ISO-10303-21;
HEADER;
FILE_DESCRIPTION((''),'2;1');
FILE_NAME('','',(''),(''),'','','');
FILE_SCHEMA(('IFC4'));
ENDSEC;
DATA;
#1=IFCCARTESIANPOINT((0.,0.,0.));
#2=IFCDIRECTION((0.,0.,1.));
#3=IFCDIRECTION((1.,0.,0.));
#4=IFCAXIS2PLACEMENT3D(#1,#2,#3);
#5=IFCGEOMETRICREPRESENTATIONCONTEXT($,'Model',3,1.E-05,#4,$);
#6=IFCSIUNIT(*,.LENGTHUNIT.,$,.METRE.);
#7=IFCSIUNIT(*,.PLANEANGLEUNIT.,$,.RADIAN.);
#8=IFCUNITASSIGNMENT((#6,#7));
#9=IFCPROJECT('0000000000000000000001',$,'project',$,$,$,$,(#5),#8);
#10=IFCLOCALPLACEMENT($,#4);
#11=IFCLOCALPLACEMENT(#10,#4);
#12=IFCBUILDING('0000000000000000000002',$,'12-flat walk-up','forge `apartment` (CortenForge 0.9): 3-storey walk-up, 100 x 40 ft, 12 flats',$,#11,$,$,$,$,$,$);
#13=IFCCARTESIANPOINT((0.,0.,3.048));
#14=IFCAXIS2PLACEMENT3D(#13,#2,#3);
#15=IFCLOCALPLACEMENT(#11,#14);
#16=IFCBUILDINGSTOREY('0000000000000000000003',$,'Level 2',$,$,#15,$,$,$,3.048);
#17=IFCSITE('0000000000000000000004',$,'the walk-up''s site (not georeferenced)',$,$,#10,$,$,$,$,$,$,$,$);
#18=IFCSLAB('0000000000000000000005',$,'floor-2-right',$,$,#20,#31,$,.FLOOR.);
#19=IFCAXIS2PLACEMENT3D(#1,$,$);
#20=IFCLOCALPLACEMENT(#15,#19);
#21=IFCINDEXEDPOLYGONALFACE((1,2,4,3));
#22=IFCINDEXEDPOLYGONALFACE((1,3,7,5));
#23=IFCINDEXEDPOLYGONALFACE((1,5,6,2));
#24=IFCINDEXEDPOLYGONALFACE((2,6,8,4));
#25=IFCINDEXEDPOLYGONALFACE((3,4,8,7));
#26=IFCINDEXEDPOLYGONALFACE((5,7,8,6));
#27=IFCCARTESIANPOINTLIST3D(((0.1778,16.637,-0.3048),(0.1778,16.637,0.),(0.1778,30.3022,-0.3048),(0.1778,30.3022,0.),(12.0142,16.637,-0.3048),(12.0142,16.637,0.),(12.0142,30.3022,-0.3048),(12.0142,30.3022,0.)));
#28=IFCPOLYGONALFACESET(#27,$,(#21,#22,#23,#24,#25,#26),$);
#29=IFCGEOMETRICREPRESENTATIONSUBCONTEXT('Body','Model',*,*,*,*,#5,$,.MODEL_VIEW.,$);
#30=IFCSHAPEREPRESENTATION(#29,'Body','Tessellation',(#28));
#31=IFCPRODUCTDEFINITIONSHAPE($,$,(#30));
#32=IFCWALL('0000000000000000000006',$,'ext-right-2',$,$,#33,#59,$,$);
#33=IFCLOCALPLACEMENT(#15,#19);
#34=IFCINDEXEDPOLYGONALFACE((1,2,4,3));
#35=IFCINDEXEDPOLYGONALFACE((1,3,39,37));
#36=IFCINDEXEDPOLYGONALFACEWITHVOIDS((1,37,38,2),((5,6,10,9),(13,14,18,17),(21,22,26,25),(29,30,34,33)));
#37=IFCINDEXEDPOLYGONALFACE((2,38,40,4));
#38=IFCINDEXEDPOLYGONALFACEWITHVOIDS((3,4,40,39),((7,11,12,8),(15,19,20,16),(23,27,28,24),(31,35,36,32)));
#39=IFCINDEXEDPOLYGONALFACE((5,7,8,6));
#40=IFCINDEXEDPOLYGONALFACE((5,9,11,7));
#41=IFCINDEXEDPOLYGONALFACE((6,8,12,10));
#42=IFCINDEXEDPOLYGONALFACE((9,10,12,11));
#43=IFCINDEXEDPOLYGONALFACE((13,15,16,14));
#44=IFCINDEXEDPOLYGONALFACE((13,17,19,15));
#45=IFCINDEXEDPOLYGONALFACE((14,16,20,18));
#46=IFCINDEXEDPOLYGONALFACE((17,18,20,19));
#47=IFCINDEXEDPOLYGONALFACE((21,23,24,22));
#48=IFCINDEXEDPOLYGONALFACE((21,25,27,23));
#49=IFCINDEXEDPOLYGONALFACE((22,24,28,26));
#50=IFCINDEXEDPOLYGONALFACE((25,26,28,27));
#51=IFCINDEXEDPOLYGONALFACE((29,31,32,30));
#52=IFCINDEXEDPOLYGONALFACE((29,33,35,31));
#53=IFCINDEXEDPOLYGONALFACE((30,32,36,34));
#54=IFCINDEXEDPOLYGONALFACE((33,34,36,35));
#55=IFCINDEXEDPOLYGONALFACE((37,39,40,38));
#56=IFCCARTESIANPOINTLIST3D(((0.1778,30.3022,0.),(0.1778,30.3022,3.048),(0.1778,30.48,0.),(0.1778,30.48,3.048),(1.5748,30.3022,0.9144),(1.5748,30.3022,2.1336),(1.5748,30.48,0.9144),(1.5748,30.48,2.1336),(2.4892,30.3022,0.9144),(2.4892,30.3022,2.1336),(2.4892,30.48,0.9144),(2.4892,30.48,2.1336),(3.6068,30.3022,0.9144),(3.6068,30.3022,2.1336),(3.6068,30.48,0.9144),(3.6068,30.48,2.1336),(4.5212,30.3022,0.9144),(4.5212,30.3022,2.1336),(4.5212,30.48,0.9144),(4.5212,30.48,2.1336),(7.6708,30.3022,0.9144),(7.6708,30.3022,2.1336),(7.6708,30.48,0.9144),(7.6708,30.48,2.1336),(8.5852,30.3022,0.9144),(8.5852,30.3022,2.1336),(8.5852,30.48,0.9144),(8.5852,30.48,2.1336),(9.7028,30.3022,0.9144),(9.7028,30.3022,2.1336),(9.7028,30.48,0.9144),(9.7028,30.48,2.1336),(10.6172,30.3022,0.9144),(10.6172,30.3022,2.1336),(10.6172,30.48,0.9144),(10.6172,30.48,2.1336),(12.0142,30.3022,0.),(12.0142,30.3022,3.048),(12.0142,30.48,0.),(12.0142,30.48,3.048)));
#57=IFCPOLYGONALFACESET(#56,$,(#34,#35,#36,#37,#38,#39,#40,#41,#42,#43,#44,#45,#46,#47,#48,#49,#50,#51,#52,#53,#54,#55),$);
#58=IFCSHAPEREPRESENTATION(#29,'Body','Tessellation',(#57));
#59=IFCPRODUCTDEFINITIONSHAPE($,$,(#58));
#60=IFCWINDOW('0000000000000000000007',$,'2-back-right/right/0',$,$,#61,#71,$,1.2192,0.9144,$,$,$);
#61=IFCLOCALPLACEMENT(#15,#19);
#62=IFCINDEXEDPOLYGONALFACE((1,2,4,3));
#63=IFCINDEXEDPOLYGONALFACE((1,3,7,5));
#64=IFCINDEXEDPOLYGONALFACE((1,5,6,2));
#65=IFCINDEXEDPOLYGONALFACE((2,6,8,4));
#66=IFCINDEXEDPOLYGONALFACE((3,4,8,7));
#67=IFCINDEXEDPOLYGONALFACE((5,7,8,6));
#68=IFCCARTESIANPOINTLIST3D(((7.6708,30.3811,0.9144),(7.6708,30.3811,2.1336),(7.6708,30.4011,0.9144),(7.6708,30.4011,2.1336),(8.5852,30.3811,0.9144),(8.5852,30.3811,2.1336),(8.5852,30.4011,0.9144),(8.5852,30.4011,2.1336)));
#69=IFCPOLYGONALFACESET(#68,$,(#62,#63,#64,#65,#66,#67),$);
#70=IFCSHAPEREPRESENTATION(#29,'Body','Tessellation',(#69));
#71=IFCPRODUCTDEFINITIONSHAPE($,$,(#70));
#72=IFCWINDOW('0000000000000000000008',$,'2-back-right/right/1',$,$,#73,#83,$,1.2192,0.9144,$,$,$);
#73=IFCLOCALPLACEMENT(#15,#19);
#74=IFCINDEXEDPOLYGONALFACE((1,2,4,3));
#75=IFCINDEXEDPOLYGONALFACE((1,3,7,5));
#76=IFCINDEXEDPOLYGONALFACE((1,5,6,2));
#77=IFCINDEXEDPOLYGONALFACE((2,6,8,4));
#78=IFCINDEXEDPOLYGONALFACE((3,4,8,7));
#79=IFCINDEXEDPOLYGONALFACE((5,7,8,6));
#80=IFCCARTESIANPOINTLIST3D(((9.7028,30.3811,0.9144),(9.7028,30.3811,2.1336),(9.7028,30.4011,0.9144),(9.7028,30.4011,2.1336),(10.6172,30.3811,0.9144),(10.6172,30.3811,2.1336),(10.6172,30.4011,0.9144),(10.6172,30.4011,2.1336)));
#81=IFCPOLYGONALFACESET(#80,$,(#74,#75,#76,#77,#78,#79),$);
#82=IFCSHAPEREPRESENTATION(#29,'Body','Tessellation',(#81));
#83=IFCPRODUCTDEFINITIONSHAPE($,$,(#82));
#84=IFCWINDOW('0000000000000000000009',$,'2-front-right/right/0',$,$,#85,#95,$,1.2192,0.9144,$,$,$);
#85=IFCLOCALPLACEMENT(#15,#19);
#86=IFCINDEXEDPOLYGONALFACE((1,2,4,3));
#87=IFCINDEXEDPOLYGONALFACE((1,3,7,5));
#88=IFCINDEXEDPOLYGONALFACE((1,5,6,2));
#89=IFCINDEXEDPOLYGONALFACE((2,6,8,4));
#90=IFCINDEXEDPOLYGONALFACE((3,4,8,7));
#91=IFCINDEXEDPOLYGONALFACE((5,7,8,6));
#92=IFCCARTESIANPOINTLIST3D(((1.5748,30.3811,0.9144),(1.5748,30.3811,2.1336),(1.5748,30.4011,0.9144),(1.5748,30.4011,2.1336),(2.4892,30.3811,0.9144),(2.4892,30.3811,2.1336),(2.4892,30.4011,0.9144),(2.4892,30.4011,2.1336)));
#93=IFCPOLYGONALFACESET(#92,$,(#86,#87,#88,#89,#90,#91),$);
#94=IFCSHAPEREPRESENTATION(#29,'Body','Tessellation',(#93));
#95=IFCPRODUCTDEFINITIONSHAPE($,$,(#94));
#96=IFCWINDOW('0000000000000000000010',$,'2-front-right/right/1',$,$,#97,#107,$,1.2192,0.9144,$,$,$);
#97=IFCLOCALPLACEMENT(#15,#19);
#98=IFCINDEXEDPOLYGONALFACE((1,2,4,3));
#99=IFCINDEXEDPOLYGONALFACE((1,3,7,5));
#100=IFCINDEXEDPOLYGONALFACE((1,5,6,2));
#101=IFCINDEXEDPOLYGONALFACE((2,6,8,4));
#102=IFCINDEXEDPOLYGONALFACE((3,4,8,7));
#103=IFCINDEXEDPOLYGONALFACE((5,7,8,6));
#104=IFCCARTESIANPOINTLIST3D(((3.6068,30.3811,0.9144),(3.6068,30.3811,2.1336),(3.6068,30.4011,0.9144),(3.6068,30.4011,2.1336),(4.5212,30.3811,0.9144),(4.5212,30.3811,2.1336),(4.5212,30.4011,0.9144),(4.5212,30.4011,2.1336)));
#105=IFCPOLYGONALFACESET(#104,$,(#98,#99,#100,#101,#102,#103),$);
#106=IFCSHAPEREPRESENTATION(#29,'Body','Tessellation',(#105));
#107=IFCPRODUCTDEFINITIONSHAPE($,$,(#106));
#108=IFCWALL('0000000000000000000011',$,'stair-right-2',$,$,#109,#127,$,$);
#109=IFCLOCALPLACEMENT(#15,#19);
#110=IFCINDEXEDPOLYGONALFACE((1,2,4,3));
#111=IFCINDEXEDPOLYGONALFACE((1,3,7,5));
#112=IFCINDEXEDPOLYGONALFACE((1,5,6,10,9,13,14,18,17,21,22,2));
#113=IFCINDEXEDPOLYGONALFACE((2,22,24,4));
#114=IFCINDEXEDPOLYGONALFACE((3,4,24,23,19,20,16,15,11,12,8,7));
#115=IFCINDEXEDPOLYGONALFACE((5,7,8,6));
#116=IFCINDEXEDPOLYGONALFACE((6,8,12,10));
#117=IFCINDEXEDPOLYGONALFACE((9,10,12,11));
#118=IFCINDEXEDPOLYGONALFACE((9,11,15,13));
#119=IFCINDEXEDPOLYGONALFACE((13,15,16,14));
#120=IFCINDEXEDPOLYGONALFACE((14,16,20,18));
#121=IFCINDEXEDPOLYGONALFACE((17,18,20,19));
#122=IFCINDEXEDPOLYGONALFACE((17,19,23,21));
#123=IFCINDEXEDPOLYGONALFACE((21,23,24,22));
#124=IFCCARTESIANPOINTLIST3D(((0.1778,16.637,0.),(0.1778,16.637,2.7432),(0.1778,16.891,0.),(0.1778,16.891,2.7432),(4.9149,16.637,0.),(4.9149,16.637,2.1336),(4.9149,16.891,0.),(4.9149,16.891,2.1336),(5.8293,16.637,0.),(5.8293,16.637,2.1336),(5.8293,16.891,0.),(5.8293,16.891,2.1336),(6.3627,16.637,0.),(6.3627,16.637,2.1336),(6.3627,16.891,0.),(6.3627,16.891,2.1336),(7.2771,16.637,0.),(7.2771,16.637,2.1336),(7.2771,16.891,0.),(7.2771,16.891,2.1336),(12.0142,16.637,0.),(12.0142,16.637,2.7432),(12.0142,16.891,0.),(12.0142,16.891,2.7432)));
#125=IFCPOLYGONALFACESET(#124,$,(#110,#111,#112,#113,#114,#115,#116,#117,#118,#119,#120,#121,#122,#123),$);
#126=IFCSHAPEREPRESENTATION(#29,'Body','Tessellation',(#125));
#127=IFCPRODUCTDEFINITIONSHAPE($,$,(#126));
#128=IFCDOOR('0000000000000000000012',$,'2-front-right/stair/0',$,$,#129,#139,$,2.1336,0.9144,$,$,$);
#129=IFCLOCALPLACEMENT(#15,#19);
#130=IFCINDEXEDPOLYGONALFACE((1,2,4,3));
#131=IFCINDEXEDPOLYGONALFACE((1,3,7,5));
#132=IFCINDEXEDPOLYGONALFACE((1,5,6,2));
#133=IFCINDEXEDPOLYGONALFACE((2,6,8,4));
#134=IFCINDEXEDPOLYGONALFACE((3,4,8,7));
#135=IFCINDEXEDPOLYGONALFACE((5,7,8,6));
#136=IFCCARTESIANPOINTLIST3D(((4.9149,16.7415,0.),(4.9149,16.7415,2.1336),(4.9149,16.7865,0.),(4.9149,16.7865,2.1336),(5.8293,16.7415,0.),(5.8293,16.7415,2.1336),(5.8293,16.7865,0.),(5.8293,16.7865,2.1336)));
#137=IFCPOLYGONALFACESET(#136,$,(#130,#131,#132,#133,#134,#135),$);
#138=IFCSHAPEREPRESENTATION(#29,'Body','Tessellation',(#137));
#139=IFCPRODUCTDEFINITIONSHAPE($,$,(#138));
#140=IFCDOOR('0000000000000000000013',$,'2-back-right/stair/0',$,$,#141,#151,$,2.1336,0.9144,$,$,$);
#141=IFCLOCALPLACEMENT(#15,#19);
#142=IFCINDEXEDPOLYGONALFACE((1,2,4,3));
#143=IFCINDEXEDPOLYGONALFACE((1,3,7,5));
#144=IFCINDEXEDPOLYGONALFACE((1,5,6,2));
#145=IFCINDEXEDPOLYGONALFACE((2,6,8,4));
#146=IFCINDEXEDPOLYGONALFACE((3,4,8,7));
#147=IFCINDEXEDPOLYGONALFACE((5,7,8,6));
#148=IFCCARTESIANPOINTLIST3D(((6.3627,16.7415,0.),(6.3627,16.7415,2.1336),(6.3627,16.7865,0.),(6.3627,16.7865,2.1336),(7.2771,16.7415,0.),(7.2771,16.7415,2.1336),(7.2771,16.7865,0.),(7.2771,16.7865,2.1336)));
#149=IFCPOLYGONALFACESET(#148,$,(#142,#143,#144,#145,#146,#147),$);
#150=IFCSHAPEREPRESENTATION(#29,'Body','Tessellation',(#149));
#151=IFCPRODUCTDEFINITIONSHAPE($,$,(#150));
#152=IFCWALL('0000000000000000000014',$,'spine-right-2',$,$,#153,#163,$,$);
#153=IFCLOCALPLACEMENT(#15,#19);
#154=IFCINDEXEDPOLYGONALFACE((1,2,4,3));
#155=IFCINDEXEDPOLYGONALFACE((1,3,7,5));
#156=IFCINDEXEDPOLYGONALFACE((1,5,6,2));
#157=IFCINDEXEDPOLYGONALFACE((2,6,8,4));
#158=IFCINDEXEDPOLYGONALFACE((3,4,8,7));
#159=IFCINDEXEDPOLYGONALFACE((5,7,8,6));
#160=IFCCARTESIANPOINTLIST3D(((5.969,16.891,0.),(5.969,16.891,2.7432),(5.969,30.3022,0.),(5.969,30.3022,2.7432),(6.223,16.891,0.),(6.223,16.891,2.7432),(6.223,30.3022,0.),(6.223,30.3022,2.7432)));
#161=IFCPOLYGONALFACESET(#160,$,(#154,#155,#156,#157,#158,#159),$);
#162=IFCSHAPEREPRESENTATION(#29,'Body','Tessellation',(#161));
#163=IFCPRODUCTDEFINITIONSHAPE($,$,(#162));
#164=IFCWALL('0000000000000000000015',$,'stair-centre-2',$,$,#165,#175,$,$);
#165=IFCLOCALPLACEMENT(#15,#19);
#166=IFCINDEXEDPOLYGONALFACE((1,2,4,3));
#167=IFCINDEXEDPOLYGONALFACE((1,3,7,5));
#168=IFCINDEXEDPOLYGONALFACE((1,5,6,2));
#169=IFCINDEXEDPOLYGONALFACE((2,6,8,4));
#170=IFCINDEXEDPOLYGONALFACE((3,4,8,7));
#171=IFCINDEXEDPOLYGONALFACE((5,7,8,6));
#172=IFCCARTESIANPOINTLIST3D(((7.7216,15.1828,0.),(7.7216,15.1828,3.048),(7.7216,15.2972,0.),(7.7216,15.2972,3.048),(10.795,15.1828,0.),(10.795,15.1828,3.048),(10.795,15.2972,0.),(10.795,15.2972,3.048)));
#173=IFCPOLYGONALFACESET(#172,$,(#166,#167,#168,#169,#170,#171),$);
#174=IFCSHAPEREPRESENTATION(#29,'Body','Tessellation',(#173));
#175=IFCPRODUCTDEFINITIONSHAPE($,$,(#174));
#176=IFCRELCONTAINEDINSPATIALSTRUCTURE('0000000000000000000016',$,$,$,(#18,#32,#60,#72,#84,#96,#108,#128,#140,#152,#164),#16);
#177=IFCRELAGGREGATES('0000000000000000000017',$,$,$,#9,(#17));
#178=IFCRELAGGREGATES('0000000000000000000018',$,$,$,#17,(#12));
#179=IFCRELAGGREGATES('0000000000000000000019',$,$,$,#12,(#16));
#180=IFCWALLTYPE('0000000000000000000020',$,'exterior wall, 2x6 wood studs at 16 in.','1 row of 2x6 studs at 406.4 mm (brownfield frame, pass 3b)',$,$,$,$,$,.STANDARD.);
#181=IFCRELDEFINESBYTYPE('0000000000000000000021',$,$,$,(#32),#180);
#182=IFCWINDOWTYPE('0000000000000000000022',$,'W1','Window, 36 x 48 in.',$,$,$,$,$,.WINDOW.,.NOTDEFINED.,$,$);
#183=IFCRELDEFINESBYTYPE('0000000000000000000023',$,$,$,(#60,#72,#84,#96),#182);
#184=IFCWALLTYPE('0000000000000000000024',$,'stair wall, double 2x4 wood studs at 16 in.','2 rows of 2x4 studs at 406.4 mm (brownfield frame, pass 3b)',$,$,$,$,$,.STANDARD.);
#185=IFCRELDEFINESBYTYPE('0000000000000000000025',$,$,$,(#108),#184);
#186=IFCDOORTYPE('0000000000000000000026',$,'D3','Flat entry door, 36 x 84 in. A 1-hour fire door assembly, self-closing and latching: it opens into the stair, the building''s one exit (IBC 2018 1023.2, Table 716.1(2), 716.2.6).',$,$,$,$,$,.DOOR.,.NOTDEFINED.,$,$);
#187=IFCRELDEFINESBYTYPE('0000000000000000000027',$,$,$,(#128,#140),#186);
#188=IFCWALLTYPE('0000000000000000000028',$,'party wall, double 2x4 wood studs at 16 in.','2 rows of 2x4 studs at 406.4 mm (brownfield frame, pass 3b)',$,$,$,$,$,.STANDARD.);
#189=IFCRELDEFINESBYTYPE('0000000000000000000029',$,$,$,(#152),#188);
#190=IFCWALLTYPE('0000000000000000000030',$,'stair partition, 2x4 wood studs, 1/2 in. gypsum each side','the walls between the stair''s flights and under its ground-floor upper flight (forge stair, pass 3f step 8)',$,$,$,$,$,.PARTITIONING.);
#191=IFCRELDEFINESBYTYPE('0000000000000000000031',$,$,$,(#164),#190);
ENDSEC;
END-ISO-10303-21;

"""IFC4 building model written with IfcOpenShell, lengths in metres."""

from ifc_helpers import new_model, si_unit, frame, frame_2d, origin, origin_with_axes, place, context, subcontext, project, spatial, rectangle, extrude, type_object, element, fill, save


model = new_model("IFC4")

# Units and contexts
model_context = context("Model", 3, precision=1e-05, world=origin_with_axes())
body_context = subcontext(model_context, "Body", "Model", "MODEL_VIEW")
ifc_project = project(units=[si_unit("LENGTHUNIT", "METRE"), si_unit("PLANEANGLEUNIT", "RADIAN")], contexts=[model_context])

# Site, building, storey
site_placement = place(None, origin_with_axes())
site = spatial("IfcSite", under=ifc_project, at=site_placement, Name="the walk-up's site (not georeferenced)")
building_placement = place(site_placement, origin_with_axes())
building = spatial("IfcBuilding", under=site, at=building_placement, Name="12-flat walk-up", Description="forge `apartment` (CortenForge 0.9): 3-storey walk-up, 100 x 40 ft, 12 flats")
storey_placement = place(building_placement, frame((0.0, 0.0, 3.048), z_axis=(0.0, 0.0, 1.0), x_axis=(1.0, 0.0, 0.0)))
storey = spatial("IfcBuildingStorey", under=building, at=storey_placement, Name="Level 2", Elevation=3.048)

# Slab
slab_placement = place(storey_placement, frame((0.1778, 16.637, -0.3048), z_axis=(0.0, 0.0, 1.0), x_axis=(1.0, 0.0, 0.0)))
element("IfcSlab", 1, at=slab_placement, inside=storey, Name="floor-2-right", PredefinedType="FLOOR", context=body_context, shape_type="SweptSolid", body=[
    extrude(rectangle(XDim=11.8364, YDim=13.6652, at=frame_2d((5.9182, 6.8326))), origin(), (0.0, 0.0, 1.0), 0.3048),
])

# Wall, openings, windows
wall_type_1 = type_object("IfcWallType", Name="exterior wall, 2x6 wood studs at 16 in.", Description="1 row of 2x6 studs at 406.4 mm (brownfield frame, pass 3b)", PredefinedType="STANDARD")
wall_1_placement = place(storey_placement, frame((0.1778, 30.3022, 0.0), z_axis=(0.0, 0.0, 1.0), x_axis=(1.0, 0.0, 0.0)))
wall_1 = element("IfcWall", 2, at=wall_1_placement, inside=storey, type_object=wall_type_1, Name="ext-right-2", context=body_context, shape_type="SweptSolid", body=[
    extrude(rectangle(XDim=11.8364, YDim=0.1778, at=frame_2d((5.9182, 0.0889))), origin(), (0.0, 0.0, 1.0), 3.048),
])
opening_1_placement = place(wall_1_placement, frame((8.4074, 0.1778, 0.9144), z_axis=(0.0, 0.0, 1.0), x_axis=(-1.0, 0.0, 0.0)))
opening_1 = element("IfcOpeningElement", 3, at=opening_1_placement, cuts=wall_1, PredefinedType="OPENING", context=body_context, shape_type="SweptSolid", body=[
    extrude(rectangle(XDim=0.9144, YDim=0.1778, at=frame_2d((0.4572, 0.0889))), origin(), (0.0, 0.0, 1.0), 1.2192),
])
opening_2_placement = place(wall_1_placement, frame((10.4394, 0.1778, 0.9144), z_axis=(0.0, 0.0, 1.0), x_axis=(-1.0, 0.0, 0.0)))
opening_2 = element("IfcOpeningElement", 4, at=opening_2_placement, cuts=wall_1, PredefinedType="OPENING", context=body_context, shape_type="SweptSolid", body=[
    extrude(rectangle(XDim=0.9144, YDim=0.1778, at=frame_2d((0.4572, 0.0889))), origin(), (0.0, 0.0, 1.0), 1.2192),
])
opening_3_placement = place(wall_1_placement, frame((2.3114, 0.1778, 0.9144), z_axis=(0.0, 0.0, 1.0), x_axis=(-1.0, 0.0, 0.0)))
opening_3 = element("IfcOpeningElement", 5, at=opening_3_placement, cuts=wall_1, PredefinedType="OPENING", context=body_context, shape_type="SweptSolid", body=[
    extrude(rectangle(XDim=0.9144, YDim=0.1778, at=frame_2d((0.4572, 0.0889))), origin(), (0.0, 0.0, 1.0), 1.2192),
])
opening_4_placement = place(wall_1_placement, frame((4.3434, 0.1778, 0.9144), z_axis=(0.0, 0.0, 1.0), x_axis=(-1.0, 0.0, 0.0)))
opening_4 = element("IfcOpeningElement", 6, at=opening_4_placement, cuts=wall_1, PredefinedType="OPENING", context=body_context, shape_type="SweptSolid", body=[
    extrude(rectangle(XDim=0.9144, YDim=0.1778, at=frame_2d((0.4572, 0.0889))), origin(), (0.0, 0.0, 1.0), 1.2192),
])
window_type = type_object("IfcWindowType", Name="W1", Description="Window, 36 x 48 in.", PartitioningType="NOTDEFINED", PredefinedType="WINDOW")
window_1_placement = place(opening_1_placement, frame((0.0, 0.0789, 0.0), z_axis=(0.0, 0.0, 1.0), x_axis=(1.0, 0.0, 0.0)))
window_1 = element("IfcWindow", 7, at=window_1_placement, inside=storey, type_object=window_type, Name="2-back-right/right/0", OverallHeight=1.2192, OverallWidth=0.9144, context=body_context, shape_type="SweptSolid", body=[
    extrude(rectangle(XDim=0.9144, YDim=0.02, at=frame_2d((0.4572, 0.01))), origin(), (0.0, 0.0, 1.0), 1.2192),
])
fill(opening_1, window_1)
window_2_placement = place(opening_2_placement, frame((0.0, 0.0789, 0.0), z_axis=(0.0, 0.0, 1.0), x_axis=(1.0, 0.0, 0.0)))
window_2 = element("IfcWindow", 8, at=window_2_placement, inside=storey, type_object=window_type, Name="2-back-right/right/1", OverallHeight=1.2192, OverallWidth=0.9144, context=body_context, shape_type="SweptSolid", body=[
    extrude(rectangle(XDim=0.9144, YDim=0.02, at=frame_2d((0.4572, 0.01))), origin(), (0.0, 0.0, 1.0), 1.2192),
])
fill(opening_2, window_2)
window_3_placement = place(opening_3_placement, frame((0.0, 0.0789, 0.0), z_axis=(0.0, 0.0, 1.0), x_axis=(1.0, 0.0, 0.0)))
window_3 = element("IfcWindow", 9, at=window_3_placement, inside=storey, type_object=window_type, Name="2-front-right/right/0", OverallHeight=1.2192, OverallWidth=0.9144, context=body_context, shape_type="SweptSolid", body=[
    extrude(rectangle(XDim=0.9144, YDim=0.02, at=frame_2d((0.4572, 0.01))), origin(), (0.0, 0.0, 1.0), 1.2192),
])
fill(opening_3, window_3)
window_4_placement = place(opening_4_placement, frame((0.0, 0.0789, 0.0), z_axis=(0.0, 0.0, 1.0), x_axis=(1.0, 0.0, 0.0)))
window_4 = element("IfcWindow", 10, at=window_4_placement, inside=storey, type_object=window_type, Name="2-front-right/right/1", OverallHeight=1.2192, OverallWidth=0.9144, context=body_context, shape_type="SweptSolid", body=[
    extrude(rectangle(XDim=0.9144, YDim=0.02, at=frame_2d((0.4572, 0.01))), origin(), (0.0, 0.0, 1.0), 1.2192),
])
fill(opening_4, window_4)

# Wall, openings, doors
wall_type_2 = type_object("IfcWallType", Name="stair wall, double 2x4 wood studs at 16 in.", Description="2 rows of 2x4 studs at 406.4 mm (brownfield frame, pass 3b)", PredefinedType="STANDARD")
wall_2_placement = place(storey_placement, frame((0.1778, 16.637, 0.0), z_axis=(0.0, 0.0, 1.0), x_axis=(1.0, 0.0, 0.0)))
wall_2 = element("IfcWall", 11, at=wall_2_placement, inside=storey, type_object=wall_type_2, Name="stair-right-2", context=body_context, shape_type="SweptSolid", body=[
    extrude(rectangle(XDim=11.8364, YDim=0.254, at=frame_2d((5.9182, 0.127))), origin(), (0.0, 0.0, 1.0), 2.7432),
])
opening_5_placement = place(wall_2_placement, frame((5.6515, 0.254, 0.0), z_axis=(0.0, 0.0, 1.0), x_axis=(-1.0, 0.0, 0.0)))
opening_5 = element("IfcOpeningElement", 12, at=opening_5_placement, cuts=wall_2, PredefinedType="OPENING", context=body_context, shape_type="SweptSolid", body=[
    extrude(rectangle(XDim=0.9144, YDim=0.254, at=frame_2d((0.4572, 0.127))), origin(), (0.0, 0.0, 1.0), 2.1336),
])
opening_6_placement = place(wall_2_placement, frame((7.0993, 0.254, 0.0), z_axis=(0.0, 0.0, 1.0), x_axis=(-1.0, 0.0, 0.0)))
opening_6 = element("IfcOpeningElement", 13, at=opening_6_placement, cuts=wall_2, PredefinedType="OPENING", context=body_context, shape_type="SweptSolid", body=[
    extrude(rectangle(XDim=0.9144, YDim=0.254, at=frame_2d((0.4572, 0.127))), origin(), (0.0, 0.0, 1.0), 2.1336),
])
door_type = type_object("IfcDoorType", Name="D3", Description="Flat entry door, 36 x 84 in. A 1-hour fire door assembly, self-closing and latching: it opens into the stair, the building's one exit (IBC 2018 1023.2, Table 716.1(2), 716.2.6).", OperationType="NOTDEFINED", PredefinedType="DOOR")
door_1_placement = place(opening_5_placement, frame((0.0, 0.1045, 0.0), z_axis=(0.0, 0.0, 1.0), x_axis=(1.0, 0.0, 0.0)))
door_1 = element("IfcDoor", 14, at=door_1_placement, inside=storey, type_object=door_type, Name="2-front-right/stair/0", OverallHeight=2.1336, OverallWidth=0.9144, context=body_context, shape_type="SweptSolid", body=[
    extrude(rectangle(XDim=0.9144, YDim=0.045, at=frame_2d((0.4572, 0.0225))), origin(), (0.0, 0.0, 1.0), 2.1336),
])
fill(opening_5, door_1)
door_2_placement = place(opening_6_placement, frame((0.0, 0.1045, 0.0), z_axis=(0.0, 0.0, 1.0), x_axis=(1.0, 0.0, 0.0)))
door_2 = element("IfcDoor", 15, at=door_2_placement, inside=storey, type_object=door_type, Name="2-back-right/stair/0", OverallHeight=2.1336, OverallWidth=0.9144, context=body_context, shape_type="SweptSolid", body=[
    extrude(rectangle(XDim=0.9144, YDim=0.045, at=frame_2d((0.4572, 0.0225))), origin(), (0.0, 0.0, 1.0), 2.1336),
])
fill(opening_6, door_2)

# Walls
wall_type_3 = type_object("IfcWallType", Name="party wall, double 2x4 wood studs at 16 in.", Description="2 rows of 2x4 studs at 406.4 mm (brownfield frame, pass 3b)", PredefinedType="STANDARD")
wall_3_placement = place(storey_placement, frame((5.969, 16.891, 0.0), z_axis=(0.0, 0.0, 1.0), x_axis=(1.0, 0.0, 0.0)))
element("IfcWall", 16, at=wall_3_placement, inside=storey, type_object=wall_type_3, Name="spine-right-2", context=body_context, shape_type="SweptSolid", body=[
    extrude(rectangle(XDim=0.254, YDim=13.4112, at=frame_2d((0.127, 6.7056))), origin(), (0.0, 0.0, 1.0), 2.7432),
])
wall_type_4 = type_object("IfcWallType", Name="stair partition, 2x4 wood studs, 1/2 in. gypsum each side", Description="the walls between the stair's flights and under its ground-floor upper flight (forge stair, pass 3f step 8)", PredefinedType="PARTITIONING")
wall_4_placement = place(storey_placement, frame((7.7216, 15.1829, 0.0), z_axis=(0.0, 0.0, 1.0), x_axis=(1.0, 0.0, 0.0)))
element("IfcWall", 17, at=wall_4_placement, inside=storey, type_object=wall_type_4, Name="stair-centre-2", context=body_context, shape_type="SweptSolid", body=[
    extrude(rectangle(XDim=3.0734, YDim=0.1143, at=frame_2d((1.5367, 0.0572))), origin(), (0.0, 0.0, 1.0), 3.048),
])

save(model, "model.ifc")
